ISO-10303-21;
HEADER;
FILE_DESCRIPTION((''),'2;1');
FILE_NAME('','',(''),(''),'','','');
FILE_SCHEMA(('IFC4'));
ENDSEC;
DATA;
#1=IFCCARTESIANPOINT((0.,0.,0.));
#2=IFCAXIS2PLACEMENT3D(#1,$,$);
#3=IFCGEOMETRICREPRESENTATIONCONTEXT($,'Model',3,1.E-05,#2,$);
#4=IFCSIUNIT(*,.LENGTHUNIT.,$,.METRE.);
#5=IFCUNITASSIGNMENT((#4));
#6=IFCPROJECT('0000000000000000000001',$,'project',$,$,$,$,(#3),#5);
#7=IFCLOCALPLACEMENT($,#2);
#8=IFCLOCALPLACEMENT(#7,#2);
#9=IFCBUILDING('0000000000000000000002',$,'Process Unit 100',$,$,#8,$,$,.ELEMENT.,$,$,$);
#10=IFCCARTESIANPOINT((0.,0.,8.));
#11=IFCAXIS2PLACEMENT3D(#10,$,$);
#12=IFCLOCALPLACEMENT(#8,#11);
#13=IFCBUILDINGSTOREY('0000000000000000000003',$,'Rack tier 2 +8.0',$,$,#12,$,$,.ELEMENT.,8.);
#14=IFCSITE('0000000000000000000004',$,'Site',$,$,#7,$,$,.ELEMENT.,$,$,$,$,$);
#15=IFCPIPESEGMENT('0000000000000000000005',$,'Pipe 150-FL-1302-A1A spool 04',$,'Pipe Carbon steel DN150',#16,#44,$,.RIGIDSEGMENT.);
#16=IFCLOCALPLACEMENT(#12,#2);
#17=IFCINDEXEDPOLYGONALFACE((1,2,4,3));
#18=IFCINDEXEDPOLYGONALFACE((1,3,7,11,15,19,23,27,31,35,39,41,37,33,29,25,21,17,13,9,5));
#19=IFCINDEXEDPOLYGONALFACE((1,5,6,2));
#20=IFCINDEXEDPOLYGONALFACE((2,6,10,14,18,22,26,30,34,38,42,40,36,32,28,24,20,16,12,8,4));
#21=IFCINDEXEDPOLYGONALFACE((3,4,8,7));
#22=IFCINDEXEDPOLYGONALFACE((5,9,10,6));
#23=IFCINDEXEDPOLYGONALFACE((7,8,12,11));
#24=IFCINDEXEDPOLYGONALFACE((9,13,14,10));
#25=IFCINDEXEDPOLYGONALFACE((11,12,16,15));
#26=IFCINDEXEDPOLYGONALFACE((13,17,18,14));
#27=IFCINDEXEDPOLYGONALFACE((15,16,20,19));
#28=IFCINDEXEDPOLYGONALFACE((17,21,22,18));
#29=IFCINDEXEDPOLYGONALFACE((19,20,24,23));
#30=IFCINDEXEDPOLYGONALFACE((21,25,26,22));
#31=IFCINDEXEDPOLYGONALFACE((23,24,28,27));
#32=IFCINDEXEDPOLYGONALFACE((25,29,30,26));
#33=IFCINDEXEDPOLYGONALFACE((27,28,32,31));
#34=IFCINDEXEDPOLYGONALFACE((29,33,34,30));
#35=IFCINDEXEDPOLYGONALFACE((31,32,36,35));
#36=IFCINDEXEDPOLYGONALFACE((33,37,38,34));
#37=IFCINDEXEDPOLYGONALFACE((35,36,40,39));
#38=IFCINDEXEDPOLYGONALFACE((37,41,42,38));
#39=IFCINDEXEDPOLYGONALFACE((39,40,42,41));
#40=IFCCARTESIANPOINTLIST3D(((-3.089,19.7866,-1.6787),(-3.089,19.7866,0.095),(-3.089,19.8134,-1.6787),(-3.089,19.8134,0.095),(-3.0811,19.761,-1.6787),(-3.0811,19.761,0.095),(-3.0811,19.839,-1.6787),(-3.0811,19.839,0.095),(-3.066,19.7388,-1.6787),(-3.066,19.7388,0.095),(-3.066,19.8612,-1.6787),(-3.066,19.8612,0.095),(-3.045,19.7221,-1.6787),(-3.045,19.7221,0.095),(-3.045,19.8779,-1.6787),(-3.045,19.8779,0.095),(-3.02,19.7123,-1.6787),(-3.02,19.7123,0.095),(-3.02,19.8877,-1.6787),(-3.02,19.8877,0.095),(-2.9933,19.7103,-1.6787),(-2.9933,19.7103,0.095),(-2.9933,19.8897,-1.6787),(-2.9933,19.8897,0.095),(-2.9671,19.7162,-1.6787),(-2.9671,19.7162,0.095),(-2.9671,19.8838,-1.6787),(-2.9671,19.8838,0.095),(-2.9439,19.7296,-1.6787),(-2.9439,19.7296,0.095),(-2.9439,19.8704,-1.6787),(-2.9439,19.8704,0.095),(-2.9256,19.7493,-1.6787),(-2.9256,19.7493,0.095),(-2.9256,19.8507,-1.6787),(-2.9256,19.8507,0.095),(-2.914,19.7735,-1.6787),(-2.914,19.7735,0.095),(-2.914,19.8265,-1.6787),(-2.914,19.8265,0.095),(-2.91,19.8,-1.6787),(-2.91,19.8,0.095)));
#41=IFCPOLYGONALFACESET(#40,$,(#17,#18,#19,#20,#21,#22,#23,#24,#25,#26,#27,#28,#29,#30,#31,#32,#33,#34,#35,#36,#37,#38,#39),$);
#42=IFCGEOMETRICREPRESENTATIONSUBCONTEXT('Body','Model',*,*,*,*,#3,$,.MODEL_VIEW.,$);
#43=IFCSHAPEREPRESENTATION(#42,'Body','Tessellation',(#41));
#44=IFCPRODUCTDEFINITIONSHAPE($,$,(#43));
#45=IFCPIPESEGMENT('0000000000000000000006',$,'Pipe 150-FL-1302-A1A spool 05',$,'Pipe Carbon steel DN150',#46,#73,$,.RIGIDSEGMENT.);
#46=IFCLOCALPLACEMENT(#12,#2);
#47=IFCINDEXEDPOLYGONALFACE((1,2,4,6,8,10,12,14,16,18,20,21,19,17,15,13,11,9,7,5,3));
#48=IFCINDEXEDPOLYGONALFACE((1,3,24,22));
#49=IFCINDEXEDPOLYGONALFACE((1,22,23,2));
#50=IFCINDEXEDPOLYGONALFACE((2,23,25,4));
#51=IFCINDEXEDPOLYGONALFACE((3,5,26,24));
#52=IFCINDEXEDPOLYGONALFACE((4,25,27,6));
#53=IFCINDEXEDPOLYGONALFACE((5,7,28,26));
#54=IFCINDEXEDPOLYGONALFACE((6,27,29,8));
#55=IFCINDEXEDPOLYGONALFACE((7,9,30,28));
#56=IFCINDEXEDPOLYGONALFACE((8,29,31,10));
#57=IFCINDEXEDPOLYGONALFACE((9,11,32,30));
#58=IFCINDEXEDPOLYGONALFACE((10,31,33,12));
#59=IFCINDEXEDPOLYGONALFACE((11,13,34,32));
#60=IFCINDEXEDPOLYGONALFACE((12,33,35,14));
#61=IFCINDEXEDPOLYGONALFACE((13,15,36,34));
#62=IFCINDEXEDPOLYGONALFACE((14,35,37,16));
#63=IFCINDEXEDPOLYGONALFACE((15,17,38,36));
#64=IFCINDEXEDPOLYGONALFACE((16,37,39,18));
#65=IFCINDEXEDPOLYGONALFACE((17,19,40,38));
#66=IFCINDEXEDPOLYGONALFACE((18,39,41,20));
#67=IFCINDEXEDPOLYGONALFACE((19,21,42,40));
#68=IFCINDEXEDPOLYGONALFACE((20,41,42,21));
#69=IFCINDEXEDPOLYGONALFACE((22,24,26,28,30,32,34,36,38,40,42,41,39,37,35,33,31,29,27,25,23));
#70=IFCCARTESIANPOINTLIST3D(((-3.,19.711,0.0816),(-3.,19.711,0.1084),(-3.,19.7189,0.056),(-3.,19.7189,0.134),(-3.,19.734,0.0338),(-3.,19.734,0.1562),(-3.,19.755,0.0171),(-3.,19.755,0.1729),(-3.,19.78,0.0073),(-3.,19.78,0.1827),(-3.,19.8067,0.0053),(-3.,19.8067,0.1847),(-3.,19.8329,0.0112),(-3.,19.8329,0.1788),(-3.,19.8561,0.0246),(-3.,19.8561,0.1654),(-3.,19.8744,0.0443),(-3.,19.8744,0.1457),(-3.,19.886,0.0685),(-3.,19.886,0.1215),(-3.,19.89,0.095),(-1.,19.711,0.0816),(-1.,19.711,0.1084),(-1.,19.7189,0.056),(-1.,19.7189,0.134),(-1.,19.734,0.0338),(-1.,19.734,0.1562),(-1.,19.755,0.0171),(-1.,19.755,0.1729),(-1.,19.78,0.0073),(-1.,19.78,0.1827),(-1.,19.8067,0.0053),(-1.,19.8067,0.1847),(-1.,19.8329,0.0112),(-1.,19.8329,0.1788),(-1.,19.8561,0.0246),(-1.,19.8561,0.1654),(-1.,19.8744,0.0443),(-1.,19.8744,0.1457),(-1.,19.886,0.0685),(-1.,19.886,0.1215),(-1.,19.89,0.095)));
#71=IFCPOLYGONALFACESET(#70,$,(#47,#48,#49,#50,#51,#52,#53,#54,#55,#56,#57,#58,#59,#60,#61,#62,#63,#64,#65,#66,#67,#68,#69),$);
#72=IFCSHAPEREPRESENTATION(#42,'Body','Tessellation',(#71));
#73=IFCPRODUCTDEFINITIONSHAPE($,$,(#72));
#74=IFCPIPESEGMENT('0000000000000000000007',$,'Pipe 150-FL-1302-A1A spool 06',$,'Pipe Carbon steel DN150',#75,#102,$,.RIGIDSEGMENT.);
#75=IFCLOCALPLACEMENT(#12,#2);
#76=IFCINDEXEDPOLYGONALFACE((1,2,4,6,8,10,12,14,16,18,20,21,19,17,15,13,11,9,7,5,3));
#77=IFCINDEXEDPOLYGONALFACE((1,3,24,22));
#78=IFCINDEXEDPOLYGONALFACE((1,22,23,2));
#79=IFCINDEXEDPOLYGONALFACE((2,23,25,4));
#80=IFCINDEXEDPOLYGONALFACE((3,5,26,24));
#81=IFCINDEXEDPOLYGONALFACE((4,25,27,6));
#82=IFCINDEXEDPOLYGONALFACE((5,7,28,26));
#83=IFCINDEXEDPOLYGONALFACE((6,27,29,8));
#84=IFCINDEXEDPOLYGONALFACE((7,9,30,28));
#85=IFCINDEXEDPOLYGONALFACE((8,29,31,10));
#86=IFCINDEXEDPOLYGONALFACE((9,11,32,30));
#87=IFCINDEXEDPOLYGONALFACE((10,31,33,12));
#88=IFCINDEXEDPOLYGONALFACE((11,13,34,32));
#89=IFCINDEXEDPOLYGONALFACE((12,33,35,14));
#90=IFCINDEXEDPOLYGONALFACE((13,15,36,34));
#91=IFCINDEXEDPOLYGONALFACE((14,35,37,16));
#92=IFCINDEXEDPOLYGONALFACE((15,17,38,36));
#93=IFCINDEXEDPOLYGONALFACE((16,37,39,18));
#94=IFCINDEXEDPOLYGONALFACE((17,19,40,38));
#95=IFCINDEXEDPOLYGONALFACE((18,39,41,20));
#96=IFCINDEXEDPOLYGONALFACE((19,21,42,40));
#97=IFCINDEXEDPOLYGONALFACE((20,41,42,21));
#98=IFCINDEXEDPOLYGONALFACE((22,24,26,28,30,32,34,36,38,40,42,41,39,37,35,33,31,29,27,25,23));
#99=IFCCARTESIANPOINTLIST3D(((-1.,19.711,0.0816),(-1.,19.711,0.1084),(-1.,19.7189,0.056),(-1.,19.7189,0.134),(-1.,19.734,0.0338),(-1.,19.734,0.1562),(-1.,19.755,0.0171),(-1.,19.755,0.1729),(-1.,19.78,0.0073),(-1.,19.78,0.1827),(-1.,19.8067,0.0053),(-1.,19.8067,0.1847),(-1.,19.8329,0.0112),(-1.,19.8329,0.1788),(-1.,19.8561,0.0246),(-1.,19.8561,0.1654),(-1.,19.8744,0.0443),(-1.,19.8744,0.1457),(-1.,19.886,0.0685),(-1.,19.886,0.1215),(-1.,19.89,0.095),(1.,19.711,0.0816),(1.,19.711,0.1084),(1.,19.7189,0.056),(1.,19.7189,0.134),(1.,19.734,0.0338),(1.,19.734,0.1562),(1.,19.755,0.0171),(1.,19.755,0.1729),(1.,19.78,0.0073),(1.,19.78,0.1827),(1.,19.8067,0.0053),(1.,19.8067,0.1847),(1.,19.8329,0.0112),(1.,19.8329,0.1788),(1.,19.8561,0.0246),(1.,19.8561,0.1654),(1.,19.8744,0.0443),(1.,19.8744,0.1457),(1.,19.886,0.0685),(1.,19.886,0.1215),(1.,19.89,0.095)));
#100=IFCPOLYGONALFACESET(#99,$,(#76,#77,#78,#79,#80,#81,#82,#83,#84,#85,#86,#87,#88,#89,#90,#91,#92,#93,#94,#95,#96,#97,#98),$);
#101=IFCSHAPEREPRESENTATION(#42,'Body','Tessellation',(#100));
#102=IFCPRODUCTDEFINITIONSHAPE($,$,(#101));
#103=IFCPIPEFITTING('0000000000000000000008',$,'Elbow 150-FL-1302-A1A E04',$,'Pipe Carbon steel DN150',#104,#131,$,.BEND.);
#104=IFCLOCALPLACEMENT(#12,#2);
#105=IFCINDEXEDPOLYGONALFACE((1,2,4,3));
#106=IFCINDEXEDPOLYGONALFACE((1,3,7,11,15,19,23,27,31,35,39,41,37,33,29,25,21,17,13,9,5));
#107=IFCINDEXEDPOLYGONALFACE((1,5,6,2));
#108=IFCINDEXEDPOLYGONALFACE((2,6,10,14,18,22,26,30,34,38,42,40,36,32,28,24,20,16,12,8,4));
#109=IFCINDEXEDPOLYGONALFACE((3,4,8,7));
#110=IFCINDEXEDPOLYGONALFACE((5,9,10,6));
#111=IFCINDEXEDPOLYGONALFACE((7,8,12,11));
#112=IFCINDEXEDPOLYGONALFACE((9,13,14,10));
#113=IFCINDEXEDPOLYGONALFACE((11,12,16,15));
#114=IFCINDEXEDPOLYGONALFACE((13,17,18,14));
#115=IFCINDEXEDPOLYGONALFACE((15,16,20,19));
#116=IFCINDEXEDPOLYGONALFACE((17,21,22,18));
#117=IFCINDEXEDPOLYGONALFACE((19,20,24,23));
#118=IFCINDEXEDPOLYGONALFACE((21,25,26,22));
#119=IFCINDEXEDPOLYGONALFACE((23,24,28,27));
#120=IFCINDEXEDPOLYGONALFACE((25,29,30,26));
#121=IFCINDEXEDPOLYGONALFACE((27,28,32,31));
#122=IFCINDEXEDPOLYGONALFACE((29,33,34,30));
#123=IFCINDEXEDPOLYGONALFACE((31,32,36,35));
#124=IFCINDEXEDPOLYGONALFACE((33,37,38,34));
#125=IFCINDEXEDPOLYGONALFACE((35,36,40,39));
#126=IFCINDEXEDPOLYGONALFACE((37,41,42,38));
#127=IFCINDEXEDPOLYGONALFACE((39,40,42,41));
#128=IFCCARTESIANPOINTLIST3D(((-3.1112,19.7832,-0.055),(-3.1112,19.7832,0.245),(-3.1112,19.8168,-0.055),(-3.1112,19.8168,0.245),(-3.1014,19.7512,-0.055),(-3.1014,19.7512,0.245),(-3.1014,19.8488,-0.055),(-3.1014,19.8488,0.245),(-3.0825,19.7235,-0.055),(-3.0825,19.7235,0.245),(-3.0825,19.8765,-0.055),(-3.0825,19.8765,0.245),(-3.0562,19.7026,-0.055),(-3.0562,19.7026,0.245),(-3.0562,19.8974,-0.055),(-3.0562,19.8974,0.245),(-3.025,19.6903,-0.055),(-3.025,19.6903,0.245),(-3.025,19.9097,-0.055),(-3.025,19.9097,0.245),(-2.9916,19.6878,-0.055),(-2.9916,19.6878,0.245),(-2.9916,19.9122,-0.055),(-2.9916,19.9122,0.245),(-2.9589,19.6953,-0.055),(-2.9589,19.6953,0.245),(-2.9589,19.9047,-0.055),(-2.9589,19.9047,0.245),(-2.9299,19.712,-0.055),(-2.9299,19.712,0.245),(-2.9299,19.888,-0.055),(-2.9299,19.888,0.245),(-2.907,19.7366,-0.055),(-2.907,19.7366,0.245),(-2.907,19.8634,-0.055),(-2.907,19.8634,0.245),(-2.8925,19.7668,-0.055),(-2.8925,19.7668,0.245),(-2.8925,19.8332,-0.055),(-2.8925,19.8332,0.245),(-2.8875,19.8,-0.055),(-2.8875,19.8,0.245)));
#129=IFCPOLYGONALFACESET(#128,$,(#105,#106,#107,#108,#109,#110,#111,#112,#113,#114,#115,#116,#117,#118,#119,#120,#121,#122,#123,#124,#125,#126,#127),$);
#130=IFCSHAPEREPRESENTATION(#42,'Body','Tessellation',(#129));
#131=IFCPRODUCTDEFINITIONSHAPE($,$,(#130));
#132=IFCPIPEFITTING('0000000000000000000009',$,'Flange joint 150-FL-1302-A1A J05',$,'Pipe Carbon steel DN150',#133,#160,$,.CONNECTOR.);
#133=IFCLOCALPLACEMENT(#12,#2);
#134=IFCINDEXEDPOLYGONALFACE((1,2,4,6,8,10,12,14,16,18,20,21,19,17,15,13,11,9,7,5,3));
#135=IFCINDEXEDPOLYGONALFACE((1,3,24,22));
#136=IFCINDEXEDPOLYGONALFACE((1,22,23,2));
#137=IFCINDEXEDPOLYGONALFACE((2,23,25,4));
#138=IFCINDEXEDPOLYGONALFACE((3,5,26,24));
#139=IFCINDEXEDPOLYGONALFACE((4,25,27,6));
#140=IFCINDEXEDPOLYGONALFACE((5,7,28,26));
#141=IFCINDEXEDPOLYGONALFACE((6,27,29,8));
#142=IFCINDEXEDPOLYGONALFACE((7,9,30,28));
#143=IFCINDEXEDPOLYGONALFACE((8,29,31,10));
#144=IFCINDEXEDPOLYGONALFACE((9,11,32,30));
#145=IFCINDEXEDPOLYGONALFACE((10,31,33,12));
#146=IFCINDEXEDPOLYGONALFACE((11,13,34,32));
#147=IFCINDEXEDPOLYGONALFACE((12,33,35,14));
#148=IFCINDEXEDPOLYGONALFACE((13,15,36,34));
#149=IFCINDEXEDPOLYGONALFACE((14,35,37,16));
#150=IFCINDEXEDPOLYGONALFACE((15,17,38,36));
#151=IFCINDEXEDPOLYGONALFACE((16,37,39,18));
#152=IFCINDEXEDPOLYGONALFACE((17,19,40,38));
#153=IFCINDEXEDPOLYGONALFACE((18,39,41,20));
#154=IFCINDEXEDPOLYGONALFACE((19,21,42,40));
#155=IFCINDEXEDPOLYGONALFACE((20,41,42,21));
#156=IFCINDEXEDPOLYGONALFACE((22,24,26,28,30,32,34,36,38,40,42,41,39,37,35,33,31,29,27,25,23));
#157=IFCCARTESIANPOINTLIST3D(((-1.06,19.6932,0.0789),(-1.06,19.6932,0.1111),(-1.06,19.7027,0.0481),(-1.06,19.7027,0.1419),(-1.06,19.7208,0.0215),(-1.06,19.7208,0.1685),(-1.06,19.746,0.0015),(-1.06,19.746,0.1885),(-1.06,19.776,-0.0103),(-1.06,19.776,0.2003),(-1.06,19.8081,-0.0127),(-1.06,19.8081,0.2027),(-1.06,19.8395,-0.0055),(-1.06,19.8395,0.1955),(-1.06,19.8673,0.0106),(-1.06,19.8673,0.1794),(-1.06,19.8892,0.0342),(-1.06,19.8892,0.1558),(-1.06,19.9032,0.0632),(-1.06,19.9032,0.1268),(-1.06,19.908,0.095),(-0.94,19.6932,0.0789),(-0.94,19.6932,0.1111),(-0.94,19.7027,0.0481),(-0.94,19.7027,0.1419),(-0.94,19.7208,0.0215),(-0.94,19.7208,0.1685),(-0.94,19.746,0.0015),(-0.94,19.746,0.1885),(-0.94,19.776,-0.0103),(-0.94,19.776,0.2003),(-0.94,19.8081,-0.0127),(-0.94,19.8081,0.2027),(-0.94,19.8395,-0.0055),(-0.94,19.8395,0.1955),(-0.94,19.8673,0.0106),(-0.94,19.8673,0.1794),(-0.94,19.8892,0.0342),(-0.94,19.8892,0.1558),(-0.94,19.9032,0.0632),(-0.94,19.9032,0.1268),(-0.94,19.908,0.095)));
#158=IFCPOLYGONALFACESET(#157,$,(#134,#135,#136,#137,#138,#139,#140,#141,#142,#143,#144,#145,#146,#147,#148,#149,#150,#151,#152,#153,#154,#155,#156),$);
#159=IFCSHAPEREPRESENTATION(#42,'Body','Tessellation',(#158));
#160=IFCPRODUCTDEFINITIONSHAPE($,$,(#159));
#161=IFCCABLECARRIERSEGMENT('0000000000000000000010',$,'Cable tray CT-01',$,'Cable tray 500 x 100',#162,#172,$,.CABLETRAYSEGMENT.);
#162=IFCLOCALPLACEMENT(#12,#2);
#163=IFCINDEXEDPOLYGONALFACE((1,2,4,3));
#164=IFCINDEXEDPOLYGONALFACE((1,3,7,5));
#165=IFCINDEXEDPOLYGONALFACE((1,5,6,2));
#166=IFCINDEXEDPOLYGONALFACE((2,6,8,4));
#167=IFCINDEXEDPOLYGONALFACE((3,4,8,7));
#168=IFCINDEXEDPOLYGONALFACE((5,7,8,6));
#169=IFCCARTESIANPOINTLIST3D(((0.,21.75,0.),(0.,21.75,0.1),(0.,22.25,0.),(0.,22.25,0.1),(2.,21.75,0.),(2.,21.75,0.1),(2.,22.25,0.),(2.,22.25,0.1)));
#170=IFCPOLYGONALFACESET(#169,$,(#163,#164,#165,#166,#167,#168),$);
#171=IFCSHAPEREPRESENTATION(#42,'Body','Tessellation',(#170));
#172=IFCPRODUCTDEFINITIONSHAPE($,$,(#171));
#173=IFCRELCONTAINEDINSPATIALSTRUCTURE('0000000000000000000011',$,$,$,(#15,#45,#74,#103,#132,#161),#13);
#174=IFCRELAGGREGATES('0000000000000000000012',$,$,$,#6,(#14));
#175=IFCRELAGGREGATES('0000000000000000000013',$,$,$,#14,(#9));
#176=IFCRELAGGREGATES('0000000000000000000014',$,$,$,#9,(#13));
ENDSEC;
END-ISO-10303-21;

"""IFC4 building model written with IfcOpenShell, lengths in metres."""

from ifc_helpers import new_model, si_unit, frame, origin, place, context, subcontext, project, spatial, rectangle, circle, extrude, element, save


model = new_model("IFC4")

# Units and contexts
model_context = context("Model", 3, precision=1e-05, world=origin())
body_context = subcontext(model_context, "Body", "Model", "MODEL_VIEW")
ifc_project = project(units=[si_unit("LENGTHUNIT", "METRE")], contexts=[model_context])

# Site, building, storey
site_placement = place(None, origin())
site = spatial("IfcSite", under=ifc_project, at=site_placement, Name="Site", CompositionType="ELEMENT")
building_placement = place(site_placement, origin())
building = spatial("IfcBuilding", under=site, at=building_placement, Name="Process Unit 100", CompositionType="ELEMENT")
storey_placement = place(building_placement, frame((0.0, 0.0, 8.0)))
storey = spatial("IfcBuildingStorey", under=building, at=storey_placement, Name="Rack tier 2 +8.0", CompositionType="ELEMENT", Elevation=8.0)

# Pipe segments
pipe_segment_1_placement = place(storey_placement, frame((-3.0, 19.8, -1.6787), z_axis=(0.0, 0.0, 1.0), x_axis=(1.0, 0.0, 0.0)))
element("IfcPipeSegment", 1, at=pipe_segment_1_placement, inside=storey, Name="Pipe 150-FL-1302-A1A spool 04", ObjectType="Pipe Carbon steel DN150", PredefinedType="RIGIDSEGMENT", context=body_context, shape_type="SweptSolid", body=[
    extrude(circle(Radius=0.09), origin(), (0.0, 0.0, 1.0), 1.7738),
])
for number, where, z_axis, x_axis, name in (
    (2, (-3.0, 19.8, 0.095), (1.0, 0.0, 0.0), (0.0, 1.0, 0.0), "Pipe 150-FL-1302-A1A spool 05"),
    (3, (-1.0, 19.8, 0.095), (1.0, 0.0, 0.0), (0.0, 1.0, 0.0), "Pipe 150-FL-1302-A1A spool 06"),
):
    element("IfcPipeSegment", number, at=place(storey_placement, frame(where, z_axis=z_axis, x_axis=x_axis)), inside=storey, Name=name, ObjectType="Pipe Carbon steel DN150", PredefinedType="RIGIDSEGMENT", context=body_context, shape_type="SweptSolid", body=[
        extrude(circle(Radius=0.09), origin(), (0.0, 0.0, 1.0), 2.0),
    ])

# Pipe fittings
pipe_fitting_1_placement = place(storey_placement, frame((-3.0, 19.8, -0.055), z_axis=(0.0, 0.0, 1.0), x_axis=(1.0, 0.0, 0.0)))
element("IfcPipeFitting", 4, at=pipe_fitting_1_placement, inside=storey, Name="Elbow 150-FL-1302-A1A E04", ObjectType="Pipe Carbon steel DN150", PredefinedType="BEND", context=body_context, shape_type="SweptSolid", body=[
    extrude(circle(Radius=0.1125), origin(), (0.0, 0.0, 1.0), 0.3),
])
pipe_fitting_2_placement = place(storey_placement, frame((-1.06, 19.8, 0.095), z_axis=(1.0, 0.0, 0.0), x_axis=(0.0, 1.0, 0.0)))
element("IfcPipeFitting", 5, at=pipe_fitting_2_placement, inside=storey, Name="Flange joint 150-FL-1302-A1A J05", ObjectType="Pipe Carbon steel DN150", PredefinedType="CONNECTOR", context=body_context, shape_type="SweptSolid", body=[
    extrude(circle(Radius=0.108), origin(), (0.0, 0.0, 1.0), 0.12),
])

# Cable carrier segment
cable_carrier_segment_placement = place(storey_placement, frame((0.0, 22.0, 0.05), z_axis=(1.0, 0.0, 0.0), x_axis=(0.0, 1.0, 0.0)))
element("IfcCableCarrierSegment", 6, at=cable_carrier_segment_placement, inside=storey, Name="Cable tray CT-01", ObjectType="Cable tray 500 x 100", PredefinedType="CABLETRAYSEGMENT", context=body_context, shape_type="SweptSolid", body=[
    extrude(rectangle(XDim=0.5, YDim=0.1), origin(), (0.0, 0.0, 1.0), 2.0),
])

save(model, "model.ifc")
